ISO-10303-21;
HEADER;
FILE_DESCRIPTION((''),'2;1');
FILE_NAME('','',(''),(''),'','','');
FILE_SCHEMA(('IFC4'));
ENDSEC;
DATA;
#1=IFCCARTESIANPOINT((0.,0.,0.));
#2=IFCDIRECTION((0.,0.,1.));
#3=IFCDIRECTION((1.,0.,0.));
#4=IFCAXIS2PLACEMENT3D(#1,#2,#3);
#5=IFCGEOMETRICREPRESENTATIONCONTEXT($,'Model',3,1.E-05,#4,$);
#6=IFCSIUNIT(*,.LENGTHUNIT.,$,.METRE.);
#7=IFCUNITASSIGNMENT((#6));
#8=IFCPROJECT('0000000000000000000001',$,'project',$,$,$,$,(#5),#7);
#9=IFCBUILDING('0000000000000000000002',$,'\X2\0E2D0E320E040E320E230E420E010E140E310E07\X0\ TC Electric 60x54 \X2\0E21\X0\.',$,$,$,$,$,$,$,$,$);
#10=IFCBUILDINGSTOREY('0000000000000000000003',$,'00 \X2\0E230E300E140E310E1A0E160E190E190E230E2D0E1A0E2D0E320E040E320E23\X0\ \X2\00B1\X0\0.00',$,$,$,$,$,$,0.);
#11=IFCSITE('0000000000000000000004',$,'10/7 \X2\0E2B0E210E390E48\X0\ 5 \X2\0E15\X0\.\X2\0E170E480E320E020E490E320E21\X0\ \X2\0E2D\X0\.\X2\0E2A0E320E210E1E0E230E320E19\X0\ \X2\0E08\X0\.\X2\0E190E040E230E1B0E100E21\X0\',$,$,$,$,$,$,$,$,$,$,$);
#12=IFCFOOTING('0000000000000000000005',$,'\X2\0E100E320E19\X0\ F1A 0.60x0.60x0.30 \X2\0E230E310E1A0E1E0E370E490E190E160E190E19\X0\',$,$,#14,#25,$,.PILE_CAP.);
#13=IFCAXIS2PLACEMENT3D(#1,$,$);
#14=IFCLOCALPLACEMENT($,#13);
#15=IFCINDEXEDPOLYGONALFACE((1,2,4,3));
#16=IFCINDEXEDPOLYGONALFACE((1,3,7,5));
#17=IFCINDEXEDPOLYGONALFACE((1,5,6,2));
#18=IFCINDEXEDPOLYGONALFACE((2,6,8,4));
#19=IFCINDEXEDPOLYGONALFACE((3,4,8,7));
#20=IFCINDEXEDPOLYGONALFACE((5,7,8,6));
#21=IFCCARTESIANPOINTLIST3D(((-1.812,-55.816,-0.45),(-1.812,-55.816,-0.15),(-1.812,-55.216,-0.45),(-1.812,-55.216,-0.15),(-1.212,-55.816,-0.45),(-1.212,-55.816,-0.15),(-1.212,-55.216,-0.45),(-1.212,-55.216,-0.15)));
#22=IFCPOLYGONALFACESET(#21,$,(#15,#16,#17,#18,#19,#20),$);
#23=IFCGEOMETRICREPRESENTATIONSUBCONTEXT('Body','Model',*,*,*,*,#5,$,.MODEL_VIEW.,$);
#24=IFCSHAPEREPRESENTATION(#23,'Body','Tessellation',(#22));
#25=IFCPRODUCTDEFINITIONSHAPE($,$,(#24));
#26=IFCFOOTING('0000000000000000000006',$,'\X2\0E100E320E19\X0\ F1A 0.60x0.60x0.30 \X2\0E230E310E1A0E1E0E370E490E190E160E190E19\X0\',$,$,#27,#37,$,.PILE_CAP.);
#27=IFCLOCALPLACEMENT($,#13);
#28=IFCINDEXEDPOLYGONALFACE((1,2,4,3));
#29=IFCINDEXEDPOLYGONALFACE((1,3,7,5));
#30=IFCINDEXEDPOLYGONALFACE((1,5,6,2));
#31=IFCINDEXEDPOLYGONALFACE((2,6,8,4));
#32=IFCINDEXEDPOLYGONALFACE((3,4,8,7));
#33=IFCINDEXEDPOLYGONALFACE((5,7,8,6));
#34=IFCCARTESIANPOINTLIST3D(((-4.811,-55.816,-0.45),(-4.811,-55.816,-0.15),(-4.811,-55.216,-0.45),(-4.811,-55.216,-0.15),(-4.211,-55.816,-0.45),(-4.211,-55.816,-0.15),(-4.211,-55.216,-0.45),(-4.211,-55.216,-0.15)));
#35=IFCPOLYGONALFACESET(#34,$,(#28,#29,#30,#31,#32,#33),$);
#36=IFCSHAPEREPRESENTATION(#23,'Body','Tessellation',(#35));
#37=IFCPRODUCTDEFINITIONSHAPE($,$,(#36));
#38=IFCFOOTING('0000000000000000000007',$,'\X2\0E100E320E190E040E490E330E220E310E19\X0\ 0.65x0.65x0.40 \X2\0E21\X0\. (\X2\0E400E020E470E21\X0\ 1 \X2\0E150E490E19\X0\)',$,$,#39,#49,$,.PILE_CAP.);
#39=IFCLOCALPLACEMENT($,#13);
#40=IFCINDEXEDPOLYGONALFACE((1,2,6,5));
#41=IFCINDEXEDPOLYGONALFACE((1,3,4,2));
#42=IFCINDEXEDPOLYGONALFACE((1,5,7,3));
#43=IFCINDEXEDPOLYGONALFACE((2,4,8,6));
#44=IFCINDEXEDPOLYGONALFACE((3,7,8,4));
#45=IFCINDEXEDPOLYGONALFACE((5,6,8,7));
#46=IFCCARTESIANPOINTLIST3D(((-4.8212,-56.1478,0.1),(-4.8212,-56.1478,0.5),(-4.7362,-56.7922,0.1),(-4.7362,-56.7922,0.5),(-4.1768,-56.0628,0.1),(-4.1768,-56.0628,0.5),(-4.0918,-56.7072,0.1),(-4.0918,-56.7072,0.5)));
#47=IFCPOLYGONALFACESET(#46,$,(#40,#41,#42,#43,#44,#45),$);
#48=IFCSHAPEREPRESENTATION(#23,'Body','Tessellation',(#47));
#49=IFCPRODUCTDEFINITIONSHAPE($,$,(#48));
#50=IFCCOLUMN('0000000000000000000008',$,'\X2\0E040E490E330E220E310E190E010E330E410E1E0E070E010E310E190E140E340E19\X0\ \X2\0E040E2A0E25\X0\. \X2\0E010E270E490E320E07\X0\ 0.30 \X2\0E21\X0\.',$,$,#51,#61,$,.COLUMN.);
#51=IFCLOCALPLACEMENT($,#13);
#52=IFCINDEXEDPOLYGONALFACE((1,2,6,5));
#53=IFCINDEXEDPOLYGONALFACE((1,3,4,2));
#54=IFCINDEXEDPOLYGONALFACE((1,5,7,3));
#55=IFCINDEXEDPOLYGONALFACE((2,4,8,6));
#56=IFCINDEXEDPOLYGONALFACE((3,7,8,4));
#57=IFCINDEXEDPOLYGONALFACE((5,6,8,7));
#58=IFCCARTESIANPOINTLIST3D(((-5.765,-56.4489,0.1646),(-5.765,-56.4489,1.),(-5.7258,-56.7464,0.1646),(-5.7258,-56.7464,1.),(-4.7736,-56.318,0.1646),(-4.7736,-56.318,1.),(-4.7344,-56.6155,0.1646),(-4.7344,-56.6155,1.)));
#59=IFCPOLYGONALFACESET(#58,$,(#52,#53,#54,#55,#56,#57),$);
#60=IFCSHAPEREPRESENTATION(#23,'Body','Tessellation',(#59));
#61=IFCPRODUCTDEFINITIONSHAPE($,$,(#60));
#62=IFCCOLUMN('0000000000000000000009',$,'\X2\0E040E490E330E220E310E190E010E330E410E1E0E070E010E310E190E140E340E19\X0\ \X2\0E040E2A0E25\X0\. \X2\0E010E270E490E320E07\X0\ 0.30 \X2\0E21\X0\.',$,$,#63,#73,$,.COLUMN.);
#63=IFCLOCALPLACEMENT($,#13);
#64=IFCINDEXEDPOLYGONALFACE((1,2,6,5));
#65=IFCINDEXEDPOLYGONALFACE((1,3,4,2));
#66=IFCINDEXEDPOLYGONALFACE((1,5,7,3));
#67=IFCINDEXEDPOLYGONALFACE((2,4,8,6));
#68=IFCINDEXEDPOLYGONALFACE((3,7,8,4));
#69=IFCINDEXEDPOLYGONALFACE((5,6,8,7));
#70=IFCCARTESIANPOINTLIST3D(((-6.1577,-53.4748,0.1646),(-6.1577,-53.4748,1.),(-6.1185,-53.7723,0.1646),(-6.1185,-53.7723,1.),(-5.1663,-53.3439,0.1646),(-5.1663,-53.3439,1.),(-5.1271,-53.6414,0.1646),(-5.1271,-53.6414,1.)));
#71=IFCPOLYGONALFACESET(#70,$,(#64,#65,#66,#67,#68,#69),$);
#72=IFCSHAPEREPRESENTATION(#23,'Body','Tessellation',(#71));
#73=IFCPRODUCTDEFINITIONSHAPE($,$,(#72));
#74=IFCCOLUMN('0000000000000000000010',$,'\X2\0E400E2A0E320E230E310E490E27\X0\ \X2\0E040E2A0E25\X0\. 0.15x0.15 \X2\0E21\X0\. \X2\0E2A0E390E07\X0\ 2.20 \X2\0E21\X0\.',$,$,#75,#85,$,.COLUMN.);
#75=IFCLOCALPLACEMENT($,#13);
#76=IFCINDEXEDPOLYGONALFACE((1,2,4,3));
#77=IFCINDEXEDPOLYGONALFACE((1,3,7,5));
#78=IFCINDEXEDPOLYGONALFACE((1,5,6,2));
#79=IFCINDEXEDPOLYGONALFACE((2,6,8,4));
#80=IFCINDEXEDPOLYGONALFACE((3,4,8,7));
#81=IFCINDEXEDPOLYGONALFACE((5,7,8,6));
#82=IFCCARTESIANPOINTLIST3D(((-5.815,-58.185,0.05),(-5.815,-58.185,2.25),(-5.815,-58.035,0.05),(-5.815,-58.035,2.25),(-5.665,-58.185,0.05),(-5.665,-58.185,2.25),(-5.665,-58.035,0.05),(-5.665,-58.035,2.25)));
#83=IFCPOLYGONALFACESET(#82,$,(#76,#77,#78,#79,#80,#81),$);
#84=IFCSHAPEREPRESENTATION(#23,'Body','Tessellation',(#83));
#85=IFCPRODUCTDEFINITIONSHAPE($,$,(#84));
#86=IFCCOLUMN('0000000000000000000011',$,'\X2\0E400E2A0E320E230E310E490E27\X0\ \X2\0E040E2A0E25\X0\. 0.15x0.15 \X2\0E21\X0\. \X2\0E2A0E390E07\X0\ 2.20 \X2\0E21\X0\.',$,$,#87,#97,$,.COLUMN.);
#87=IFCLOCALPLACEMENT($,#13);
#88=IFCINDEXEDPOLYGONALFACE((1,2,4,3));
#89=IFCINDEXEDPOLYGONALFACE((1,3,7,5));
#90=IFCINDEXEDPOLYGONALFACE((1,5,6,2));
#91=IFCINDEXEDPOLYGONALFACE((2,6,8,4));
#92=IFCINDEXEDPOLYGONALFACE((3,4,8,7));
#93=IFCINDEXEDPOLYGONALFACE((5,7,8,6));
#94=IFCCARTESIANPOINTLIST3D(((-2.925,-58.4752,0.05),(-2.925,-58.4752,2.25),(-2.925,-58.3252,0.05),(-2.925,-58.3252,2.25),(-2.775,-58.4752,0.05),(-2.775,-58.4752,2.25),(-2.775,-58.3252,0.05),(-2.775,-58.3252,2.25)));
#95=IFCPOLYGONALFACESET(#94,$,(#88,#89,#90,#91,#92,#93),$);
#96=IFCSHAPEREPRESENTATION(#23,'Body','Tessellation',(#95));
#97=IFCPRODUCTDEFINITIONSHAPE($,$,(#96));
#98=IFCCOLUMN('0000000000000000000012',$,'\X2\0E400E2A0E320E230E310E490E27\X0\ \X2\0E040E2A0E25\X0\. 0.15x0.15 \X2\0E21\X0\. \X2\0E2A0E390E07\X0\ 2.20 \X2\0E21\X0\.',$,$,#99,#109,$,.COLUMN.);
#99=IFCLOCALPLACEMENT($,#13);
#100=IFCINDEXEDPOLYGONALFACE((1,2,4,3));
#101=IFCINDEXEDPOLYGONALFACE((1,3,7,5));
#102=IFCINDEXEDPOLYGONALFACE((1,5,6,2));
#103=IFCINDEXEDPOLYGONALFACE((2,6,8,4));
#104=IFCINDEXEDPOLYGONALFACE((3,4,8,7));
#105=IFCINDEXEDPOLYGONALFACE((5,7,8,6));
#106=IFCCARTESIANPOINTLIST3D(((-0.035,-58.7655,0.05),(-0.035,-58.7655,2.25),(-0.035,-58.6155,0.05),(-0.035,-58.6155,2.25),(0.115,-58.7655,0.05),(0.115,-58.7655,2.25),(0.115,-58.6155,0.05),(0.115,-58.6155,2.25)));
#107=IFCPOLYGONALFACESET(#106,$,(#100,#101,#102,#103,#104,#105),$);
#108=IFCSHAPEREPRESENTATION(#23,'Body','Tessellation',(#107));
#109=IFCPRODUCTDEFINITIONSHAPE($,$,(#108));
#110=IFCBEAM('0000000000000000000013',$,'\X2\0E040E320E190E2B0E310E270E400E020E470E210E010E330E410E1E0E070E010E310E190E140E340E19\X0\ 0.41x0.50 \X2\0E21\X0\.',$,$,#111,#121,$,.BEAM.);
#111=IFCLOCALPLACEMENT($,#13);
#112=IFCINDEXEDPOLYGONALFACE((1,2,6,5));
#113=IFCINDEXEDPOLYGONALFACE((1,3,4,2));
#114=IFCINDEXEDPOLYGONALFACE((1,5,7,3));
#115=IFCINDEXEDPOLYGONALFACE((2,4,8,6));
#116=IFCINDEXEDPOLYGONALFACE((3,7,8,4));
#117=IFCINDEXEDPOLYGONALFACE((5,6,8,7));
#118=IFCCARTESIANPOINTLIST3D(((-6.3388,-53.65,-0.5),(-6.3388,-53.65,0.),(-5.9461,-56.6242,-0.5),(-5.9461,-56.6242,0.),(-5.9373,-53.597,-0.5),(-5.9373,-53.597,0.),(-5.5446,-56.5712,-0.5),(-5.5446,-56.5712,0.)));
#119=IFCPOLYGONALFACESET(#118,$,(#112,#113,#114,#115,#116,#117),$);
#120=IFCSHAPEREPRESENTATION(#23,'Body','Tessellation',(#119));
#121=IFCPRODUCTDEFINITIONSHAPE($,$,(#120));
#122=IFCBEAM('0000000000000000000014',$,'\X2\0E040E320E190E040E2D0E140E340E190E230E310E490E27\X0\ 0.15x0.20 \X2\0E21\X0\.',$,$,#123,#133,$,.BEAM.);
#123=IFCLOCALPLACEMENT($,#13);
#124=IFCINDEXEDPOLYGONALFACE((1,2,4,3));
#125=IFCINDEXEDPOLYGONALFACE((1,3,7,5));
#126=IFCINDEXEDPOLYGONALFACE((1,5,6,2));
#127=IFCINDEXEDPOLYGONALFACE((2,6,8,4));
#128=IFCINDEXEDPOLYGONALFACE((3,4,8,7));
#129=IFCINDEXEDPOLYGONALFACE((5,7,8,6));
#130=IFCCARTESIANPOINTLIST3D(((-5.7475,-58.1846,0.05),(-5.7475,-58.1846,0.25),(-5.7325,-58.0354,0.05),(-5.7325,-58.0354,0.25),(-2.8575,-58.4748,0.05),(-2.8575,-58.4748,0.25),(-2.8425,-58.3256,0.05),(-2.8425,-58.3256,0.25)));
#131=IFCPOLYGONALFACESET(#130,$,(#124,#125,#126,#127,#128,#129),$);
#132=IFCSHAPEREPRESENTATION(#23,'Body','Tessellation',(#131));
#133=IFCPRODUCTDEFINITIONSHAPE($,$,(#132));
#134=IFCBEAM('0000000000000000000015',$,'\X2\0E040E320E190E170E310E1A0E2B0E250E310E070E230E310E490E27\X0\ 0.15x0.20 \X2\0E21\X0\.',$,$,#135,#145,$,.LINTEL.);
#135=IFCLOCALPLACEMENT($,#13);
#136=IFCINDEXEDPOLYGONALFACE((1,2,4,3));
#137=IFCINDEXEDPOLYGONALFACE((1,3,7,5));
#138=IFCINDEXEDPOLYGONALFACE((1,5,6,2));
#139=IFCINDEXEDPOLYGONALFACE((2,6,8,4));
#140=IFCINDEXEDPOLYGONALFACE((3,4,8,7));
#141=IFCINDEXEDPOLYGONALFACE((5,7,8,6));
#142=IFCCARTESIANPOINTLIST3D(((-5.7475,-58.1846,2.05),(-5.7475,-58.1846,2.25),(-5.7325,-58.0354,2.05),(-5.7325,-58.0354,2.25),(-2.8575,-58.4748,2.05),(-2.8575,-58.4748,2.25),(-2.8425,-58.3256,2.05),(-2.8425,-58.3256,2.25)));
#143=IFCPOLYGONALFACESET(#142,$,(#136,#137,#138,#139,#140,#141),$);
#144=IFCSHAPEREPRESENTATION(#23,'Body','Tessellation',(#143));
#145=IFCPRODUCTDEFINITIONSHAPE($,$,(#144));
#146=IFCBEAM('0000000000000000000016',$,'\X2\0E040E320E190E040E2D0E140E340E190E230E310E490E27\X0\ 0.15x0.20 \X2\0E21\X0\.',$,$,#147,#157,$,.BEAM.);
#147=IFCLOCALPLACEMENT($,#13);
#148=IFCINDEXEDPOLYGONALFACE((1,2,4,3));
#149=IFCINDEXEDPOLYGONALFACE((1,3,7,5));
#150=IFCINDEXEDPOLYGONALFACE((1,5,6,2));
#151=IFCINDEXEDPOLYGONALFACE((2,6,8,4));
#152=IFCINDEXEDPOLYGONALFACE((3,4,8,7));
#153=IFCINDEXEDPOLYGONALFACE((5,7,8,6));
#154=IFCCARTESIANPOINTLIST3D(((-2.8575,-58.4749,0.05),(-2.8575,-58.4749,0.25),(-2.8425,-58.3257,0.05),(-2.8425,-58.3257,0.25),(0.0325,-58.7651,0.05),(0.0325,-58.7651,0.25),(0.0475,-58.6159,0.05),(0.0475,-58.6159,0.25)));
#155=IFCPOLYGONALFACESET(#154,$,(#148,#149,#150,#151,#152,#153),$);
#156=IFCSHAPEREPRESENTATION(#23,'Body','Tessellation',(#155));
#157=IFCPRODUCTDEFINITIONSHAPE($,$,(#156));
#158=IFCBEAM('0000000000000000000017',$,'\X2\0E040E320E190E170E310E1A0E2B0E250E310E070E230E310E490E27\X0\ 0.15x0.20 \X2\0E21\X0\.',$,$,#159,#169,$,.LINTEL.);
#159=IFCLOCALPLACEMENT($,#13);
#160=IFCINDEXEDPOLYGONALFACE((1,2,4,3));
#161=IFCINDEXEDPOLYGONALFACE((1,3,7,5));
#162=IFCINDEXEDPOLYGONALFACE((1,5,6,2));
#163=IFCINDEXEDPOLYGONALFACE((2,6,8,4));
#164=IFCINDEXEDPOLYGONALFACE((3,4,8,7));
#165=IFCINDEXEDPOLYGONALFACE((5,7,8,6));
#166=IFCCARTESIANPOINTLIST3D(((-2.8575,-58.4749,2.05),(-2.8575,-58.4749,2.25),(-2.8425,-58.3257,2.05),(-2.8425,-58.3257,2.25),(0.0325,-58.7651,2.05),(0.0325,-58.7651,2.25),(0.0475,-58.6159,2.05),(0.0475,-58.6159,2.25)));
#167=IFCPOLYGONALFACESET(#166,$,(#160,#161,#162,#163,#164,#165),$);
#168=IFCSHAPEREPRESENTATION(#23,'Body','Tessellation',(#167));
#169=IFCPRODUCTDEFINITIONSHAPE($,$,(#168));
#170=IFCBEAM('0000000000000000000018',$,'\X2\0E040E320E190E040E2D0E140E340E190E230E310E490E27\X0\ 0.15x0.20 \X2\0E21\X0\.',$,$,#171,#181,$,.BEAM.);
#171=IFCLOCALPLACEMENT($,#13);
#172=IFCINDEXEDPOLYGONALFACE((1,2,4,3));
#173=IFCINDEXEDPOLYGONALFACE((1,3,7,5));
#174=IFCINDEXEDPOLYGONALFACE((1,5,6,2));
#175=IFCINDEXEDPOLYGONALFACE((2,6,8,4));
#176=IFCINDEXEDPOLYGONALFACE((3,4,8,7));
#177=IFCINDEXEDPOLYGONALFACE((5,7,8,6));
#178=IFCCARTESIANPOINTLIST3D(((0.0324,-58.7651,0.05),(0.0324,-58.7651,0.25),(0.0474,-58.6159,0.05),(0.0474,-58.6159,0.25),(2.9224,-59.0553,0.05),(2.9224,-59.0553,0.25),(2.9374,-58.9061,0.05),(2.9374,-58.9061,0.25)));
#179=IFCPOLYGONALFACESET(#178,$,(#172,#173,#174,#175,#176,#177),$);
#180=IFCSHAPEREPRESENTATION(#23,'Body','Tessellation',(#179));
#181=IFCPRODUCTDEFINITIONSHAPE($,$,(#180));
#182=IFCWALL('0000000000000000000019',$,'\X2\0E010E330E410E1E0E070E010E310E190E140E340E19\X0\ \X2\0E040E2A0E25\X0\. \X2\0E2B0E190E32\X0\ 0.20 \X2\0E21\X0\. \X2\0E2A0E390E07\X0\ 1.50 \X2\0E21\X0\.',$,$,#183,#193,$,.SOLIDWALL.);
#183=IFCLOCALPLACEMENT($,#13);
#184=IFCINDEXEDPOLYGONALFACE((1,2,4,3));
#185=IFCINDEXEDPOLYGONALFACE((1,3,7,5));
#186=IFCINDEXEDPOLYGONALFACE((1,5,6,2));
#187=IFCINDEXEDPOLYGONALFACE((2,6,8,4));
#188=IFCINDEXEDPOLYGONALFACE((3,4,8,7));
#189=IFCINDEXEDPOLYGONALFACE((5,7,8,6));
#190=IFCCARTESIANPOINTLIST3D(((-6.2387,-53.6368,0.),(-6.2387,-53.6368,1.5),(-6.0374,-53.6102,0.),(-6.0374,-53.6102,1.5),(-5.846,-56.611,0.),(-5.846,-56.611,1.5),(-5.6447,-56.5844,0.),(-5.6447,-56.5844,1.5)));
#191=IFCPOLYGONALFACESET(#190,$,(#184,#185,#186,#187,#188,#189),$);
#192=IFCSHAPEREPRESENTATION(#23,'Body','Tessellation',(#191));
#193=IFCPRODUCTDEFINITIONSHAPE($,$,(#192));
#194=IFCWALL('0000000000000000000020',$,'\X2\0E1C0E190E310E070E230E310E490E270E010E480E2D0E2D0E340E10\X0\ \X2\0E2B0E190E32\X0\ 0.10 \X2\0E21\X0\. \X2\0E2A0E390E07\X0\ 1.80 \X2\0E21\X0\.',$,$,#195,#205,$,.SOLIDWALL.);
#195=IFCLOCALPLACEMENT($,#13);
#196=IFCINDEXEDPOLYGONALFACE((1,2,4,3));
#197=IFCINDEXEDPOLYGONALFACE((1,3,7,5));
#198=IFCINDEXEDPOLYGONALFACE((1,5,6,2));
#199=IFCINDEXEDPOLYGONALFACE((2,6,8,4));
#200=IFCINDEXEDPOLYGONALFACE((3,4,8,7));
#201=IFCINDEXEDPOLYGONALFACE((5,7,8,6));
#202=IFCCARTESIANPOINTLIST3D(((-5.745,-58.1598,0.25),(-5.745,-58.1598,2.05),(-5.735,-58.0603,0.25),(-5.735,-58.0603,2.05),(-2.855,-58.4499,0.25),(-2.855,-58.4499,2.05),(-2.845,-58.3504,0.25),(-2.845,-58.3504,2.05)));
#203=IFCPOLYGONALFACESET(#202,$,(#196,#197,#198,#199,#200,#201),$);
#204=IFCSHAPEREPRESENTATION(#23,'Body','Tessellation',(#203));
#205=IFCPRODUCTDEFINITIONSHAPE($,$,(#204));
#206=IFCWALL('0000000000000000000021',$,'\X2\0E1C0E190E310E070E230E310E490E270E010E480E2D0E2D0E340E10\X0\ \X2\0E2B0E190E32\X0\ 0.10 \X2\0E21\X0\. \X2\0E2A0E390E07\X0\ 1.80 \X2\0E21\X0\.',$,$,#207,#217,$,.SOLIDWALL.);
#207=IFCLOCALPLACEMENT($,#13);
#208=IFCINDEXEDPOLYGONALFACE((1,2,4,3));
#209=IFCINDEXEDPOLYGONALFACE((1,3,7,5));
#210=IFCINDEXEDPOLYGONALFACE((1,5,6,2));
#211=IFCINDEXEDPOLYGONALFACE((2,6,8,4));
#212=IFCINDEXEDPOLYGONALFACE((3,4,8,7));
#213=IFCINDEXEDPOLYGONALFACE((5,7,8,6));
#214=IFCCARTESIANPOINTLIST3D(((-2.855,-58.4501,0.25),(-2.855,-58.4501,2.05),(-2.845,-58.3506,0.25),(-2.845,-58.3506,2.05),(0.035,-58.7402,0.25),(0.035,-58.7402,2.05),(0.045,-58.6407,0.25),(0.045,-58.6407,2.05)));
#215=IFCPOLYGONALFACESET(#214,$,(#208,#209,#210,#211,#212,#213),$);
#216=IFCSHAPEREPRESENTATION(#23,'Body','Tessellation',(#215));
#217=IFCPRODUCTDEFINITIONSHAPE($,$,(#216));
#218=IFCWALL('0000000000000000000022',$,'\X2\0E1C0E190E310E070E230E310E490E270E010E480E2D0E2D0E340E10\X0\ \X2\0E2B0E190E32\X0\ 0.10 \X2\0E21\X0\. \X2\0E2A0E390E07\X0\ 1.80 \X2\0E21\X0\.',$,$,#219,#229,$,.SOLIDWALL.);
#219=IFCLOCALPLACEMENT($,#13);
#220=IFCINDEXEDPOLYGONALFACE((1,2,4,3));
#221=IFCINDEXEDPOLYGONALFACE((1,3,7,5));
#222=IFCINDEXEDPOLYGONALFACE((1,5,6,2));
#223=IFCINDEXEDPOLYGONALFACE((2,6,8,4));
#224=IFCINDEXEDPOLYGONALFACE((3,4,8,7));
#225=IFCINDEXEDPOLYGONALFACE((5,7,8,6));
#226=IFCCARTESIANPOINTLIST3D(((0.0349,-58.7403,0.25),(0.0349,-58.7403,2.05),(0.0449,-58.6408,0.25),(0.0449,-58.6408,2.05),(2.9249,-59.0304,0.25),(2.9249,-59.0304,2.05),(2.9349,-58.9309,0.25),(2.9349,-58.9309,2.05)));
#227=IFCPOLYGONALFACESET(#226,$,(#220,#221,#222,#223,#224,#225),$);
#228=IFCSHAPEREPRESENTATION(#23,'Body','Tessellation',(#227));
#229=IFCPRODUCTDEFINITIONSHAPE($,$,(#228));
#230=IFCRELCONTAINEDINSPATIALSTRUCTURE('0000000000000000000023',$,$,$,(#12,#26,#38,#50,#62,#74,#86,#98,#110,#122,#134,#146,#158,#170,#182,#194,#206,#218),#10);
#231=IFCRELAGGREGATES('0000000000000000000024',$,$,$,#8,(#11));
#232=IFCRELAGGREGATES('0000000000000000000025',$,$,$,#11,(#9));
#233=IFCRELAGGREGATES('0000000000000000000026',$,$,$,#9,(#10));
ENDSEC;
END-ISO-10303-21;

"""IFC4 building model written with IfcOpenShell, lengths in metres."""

from ifc_helpers import new_model, si_unit, frame, origin, origin_with_axes, origin_2d, place, context, subcontext, project, spatial, rectangle, extrude, element, save


model = new_model("IFC4")

# Units and contexts
model_context = context("Model", 3, precision=1e-05, world=origin_with_axes())
body_context = subcontext(model_context, "Body", "Model", "MODEL_VIEW")
ifc_project = project(units=[si_unit("LENGTHUNIT", "METRE")], contexts=[model_context])

# Site, building, storey
site = spatial("IfcSite", under=ifc_project, Name="10/7 หมู่ 5 ต.ท่าข้าม อ.สามพราน จ.นครปฐม")
building = spatial("IfcBuilding", under=site, Name="อาคารโกดัง TC Electric 60x54 ม.")
storey = spatial("IfcBuildingStorey", under=building, Name="00 ระดับถนนรอบอาคาร ±0.00", Elevation=0.0)

# Footings
for number, where, z_axis, x_axis, name in (
    (1, (-1.512, -55.516, -0.45), (0.0, 0.0, 1.0), (1.0, 0.0, 0.0), "ฐาน F1A 0.60x0.60x0.30 รับพื้นถนน"),
    (2, (-4.511, -55.516, -0.45), (0.0, 0.0, 1.0), (1.0, 0.0, 0.0), "ฐาน F1A 0.60x0.60x0.30 รับพื้นถนน"),
):
    element("IfcFooting", number, at=place(None, frame(where, z_axis=z_axis, x_axis=x_axis)), inside=storey, Name=name, PredefinedType="PILE_CAP", context=body_context, shape_type="SweptSolid", body=[
        extrude(rectangle(XDim=0.6, YDim=0.6, at=origin_2d()), origin(), (0.0, 0.0, 1.0), 0.3),
    ])
footing_placement = place(None, frame((-4.4565, -56.4275, 0.1), z_axis=(0.0, 0.0, 1.0), x_axis=(0.9914, 0.1309, 0.0)))
element("IfcFooting", 3, at=footing_placement, inside=storey, Name="ฐานค้ำยัน 0.65x0.65x0.40 ม. (เข็ม 1 ต้น)", PredefinedType="PILE_CAP", context=body_context, shape_type="SweptSolid", body=[
    extrude(rectangle(XDim=0.65, YDim=0.65, at=origin_2d()), origin(), (0.0, 0.0, 1.0), 0.4),
])

# Columns
for number, where, z_axis, x_axis, name in (
    (4, (-5.2497, -56.5322, 0.1646), (0.0, 0.0, 1.0), (0.9914, 0.1309, 0.0), "ค้ำยันกำแพงกันดิน คสล. กว้าง 0.30 ม."),
    (5, (-5.6424, -53.5581, 0.1646), (0.0, 0.0, 1.0), (0.9914, 0.1309, 0.0), "ค้ำยันกำแพงกันดิน คสล. กว้าง 0.30 ม."),
):
    element("IfcColumn", number, at=place(None, frame(where, z_axis=z_axis, x_axis=x_axis)), inside=storey, Name=name, PredefinedType="COLUMN", context=body_context, shape_type="SweptSolid", body=[
        extrude(rectangle(XDim=1.0, YDim=0.3, at=origin_2d()), origin(), (0.0, 0.0, 1.0), 0.8354),
    ])
for number, where, z_axis, x_axis, name in (
    (6, (-5.74, -58.11, 0.05), (0.0, 0.0, 1.0), (1.0, 0.0, 0.0), "เสารั้ว คสล. 0.15x0.15 ม. สูง 2.20 ม."),
    (7, (-2.85, -58.4002, 0.05), (0.0, 0.0, 1.0), (1.0, 0.0, 0.0), "เสารั้ว คสล. 0.15x0.15 ม. สูง 2.20 ม."),
    (8, (0.04, -58.6905, 0.05), (0.0, 0.0, 1.0), (1.0, 0.0, 0.0), "เสารั้ว คสล. 0.15x0.15 ม. สูง 2.20 ม."),
):
    element("IfcColumn", number, at=place(None, frame(where, z_axis=z_axis, x_axis=x_axis)), inside=storey, Name=name, PredefinedType="COLUMN", context=body_context, shape_type="SweptSolid", body=[
        extrude(rectangle(XDim=0.15, YDim=0.15, at=origin_2d()), origin(), (0.0, 0.0, 1.0), 2.2),
    ])

# Beams
beam_1_placement = place(None, frame((-5.9417, -55.1106, -0.5), z_axis=(0.0, 0.0, 1.0), x_axis=(-0.1309, 0.9914, 0.0)))
element("IfcBeam", 9, at=beam_1_placement, inside=storey, Name="คานหัวเข็มกำแพงกันดิน 0.41x0.50 ม.", PredefinedType="BEAM", context=body_context, shape_type="SweptSolid", body=[
    extrude(rectangle(XDim=3.0, YDim=0.405, at=origin_2d()), origin(), (0.0, 0.0, 1.0), 0.5),
])
beam_2_placement = place(None, frame((-4.295, -58.2551, 0.05), z_axis=(0.0, 0.0, 1.0), x_axis=(0.995, -0.0999, 0.0)))
element("IfcBeam", 10, at=beam_2_placement, inside=storey, Name="คานคอดินรั้ว 0.15x0.20 ม.", PredefinedType="BEAM", context=body_context, shape_type="SweptSolid", body=[
    extrude(rectangle(XDim=2.9045, YDim=0.15, at=origin_2d()), origin(), (0.0, 0.0, 1.0), 0.2),
])
beam_3_placement = place(None, frame((-4.295, -58.2551, 2.05), z_axis=(0.0, 0.0, 1.0), x_axis=(0.995, -0.0999, 0.0)))
element("IfcBeam", 11, at=beam_3_placement, inside=storey, Name="คานทับหลังรั้ว 0.15x0.20 ม.", PredefinedType="LINTEL", context=body_context, shape_type="SweptSolid", body=[
    extrude(rectangle(XDim=2.9045, YDim=0.15, at=origin_2d()), origin(), (0.0, 0.0, 1.0), 0.2),
])
beam_4_placement = place(None, frame((-1.405, -58.5454, 0.05), z_axis=(0.0, 0.0, 1.0), x_axis=(0.995, -0.0999, 0.0)))
element("IfcBeam", 12, at=beam_4_placement, inside=storey, Name="คานคอดินรั้ว 0.15x0.20 ม.", PredefinedType="BEAM", context=body_context, shape_type="SweptSolid", body=[
    extrude(rectangle(XDim=2.9045, YDim=0.15, at=origin_2d()), origin(), (0.0, 0.0, 1.0), 0.2),
])
beam_5_placement = place(None, frame((-1.405, -58.5454, 2.05), z_axis=(0.0, 0.0, 1.0), x_axis=(0.995, -0.0999, 0.0)))
element("IfcBeam", 13, at=beam_5_placement, inside=storey, Name="คานทับหลังรั้ว 0.15x0.20 ม.", PredefinedType="LINTEL", context=body_context, shape_type="SweptSolid", body=[
    extrude(rectangle(XDim=2.9045, YDim=0.15, at=origin_2d()), origin(), (0.0, 0.0, 1.0), 0.2),
])
beam_6_placement = place(None, frame((1.4849, -58.8356, 0.05), z_axis=(0.0, 0.0, 1.0), x_axis=(0.995, -0.0999, 0.0)))
element("IfcBeam", 14, at=beam_6_placement, inside=storey, Name="คานคอดินรั้ว 0.15x0.20 ม.", PredefinedType="BEAM", context=body_context, shape_type="SweptSolid", body=[
    extrude(rectangle(XDim=2.9045, YDim=0.15, at=origin_2d()), origin(), (0.0, 0.0, 1.0), 0.2),
])

# Walls
wall_placement = place(None, frame((-5.9417, -55.1106, 0.0), z_axis=(0.0, 0.0, 1.0), x_axis=(-0.1309, 0.9914, 0.0)))
element("IfcWall", 15, at=wall_placement, inside=storey, Name="กำแพงกันดิน คสล. หนา 0.20 ม. สูง 1.50 ม.", PredefinedType="SOLIDWALL", context=body_context, shape_type="SweptSolid", body=[
    extrude(rectangle(XDim=3.0, YDim=0.203, at=origin_2d()), origin(), (0.0, 0.0, 1.0), 1.5),
])
for number, where, z_axis, x_axis, name in (
    (16, (-4.295, -58.2551, 0.25), (0.0, 0.0, 1.0), (0.995, -0.0999, 0.0), "ผนังรั้วก่ออิฐ หนา 0.10 ม. สูง 1.80 ม."),
    (17, (-1.405, -58.5454, 0.25), (0.0, 0.0, 1.0), (0.995, -0.0999, 0.0), "ผนังรั้วก่ออิฐ หนา 0.10 ม. สูง 1.80 ม."),
    (18, (1.4849, -58.8356, 0.25), (0.0, 0.0, 1.0), (0.995, -0.0999, 0.0), "ผนังรั้วก่ออิฐ หนา 0.10 ม. สูง 1.80 ม."),
):
    element("IfcWall", number, at=place(None, frame(where, z_axis=z_axis, x_axis=x_axis)), inside=storey, Name=name, PredefinedType="SOLIDWALL", context=body_context, shape_type="SweptSolid", body=[
        extrude(rectangle(XDim=2.9045, YDim=0.1, at=origin_2d()), origin(), (0.0, 0.0, 1.0), 1.8),
    ])

save(model, "model.ifc")
